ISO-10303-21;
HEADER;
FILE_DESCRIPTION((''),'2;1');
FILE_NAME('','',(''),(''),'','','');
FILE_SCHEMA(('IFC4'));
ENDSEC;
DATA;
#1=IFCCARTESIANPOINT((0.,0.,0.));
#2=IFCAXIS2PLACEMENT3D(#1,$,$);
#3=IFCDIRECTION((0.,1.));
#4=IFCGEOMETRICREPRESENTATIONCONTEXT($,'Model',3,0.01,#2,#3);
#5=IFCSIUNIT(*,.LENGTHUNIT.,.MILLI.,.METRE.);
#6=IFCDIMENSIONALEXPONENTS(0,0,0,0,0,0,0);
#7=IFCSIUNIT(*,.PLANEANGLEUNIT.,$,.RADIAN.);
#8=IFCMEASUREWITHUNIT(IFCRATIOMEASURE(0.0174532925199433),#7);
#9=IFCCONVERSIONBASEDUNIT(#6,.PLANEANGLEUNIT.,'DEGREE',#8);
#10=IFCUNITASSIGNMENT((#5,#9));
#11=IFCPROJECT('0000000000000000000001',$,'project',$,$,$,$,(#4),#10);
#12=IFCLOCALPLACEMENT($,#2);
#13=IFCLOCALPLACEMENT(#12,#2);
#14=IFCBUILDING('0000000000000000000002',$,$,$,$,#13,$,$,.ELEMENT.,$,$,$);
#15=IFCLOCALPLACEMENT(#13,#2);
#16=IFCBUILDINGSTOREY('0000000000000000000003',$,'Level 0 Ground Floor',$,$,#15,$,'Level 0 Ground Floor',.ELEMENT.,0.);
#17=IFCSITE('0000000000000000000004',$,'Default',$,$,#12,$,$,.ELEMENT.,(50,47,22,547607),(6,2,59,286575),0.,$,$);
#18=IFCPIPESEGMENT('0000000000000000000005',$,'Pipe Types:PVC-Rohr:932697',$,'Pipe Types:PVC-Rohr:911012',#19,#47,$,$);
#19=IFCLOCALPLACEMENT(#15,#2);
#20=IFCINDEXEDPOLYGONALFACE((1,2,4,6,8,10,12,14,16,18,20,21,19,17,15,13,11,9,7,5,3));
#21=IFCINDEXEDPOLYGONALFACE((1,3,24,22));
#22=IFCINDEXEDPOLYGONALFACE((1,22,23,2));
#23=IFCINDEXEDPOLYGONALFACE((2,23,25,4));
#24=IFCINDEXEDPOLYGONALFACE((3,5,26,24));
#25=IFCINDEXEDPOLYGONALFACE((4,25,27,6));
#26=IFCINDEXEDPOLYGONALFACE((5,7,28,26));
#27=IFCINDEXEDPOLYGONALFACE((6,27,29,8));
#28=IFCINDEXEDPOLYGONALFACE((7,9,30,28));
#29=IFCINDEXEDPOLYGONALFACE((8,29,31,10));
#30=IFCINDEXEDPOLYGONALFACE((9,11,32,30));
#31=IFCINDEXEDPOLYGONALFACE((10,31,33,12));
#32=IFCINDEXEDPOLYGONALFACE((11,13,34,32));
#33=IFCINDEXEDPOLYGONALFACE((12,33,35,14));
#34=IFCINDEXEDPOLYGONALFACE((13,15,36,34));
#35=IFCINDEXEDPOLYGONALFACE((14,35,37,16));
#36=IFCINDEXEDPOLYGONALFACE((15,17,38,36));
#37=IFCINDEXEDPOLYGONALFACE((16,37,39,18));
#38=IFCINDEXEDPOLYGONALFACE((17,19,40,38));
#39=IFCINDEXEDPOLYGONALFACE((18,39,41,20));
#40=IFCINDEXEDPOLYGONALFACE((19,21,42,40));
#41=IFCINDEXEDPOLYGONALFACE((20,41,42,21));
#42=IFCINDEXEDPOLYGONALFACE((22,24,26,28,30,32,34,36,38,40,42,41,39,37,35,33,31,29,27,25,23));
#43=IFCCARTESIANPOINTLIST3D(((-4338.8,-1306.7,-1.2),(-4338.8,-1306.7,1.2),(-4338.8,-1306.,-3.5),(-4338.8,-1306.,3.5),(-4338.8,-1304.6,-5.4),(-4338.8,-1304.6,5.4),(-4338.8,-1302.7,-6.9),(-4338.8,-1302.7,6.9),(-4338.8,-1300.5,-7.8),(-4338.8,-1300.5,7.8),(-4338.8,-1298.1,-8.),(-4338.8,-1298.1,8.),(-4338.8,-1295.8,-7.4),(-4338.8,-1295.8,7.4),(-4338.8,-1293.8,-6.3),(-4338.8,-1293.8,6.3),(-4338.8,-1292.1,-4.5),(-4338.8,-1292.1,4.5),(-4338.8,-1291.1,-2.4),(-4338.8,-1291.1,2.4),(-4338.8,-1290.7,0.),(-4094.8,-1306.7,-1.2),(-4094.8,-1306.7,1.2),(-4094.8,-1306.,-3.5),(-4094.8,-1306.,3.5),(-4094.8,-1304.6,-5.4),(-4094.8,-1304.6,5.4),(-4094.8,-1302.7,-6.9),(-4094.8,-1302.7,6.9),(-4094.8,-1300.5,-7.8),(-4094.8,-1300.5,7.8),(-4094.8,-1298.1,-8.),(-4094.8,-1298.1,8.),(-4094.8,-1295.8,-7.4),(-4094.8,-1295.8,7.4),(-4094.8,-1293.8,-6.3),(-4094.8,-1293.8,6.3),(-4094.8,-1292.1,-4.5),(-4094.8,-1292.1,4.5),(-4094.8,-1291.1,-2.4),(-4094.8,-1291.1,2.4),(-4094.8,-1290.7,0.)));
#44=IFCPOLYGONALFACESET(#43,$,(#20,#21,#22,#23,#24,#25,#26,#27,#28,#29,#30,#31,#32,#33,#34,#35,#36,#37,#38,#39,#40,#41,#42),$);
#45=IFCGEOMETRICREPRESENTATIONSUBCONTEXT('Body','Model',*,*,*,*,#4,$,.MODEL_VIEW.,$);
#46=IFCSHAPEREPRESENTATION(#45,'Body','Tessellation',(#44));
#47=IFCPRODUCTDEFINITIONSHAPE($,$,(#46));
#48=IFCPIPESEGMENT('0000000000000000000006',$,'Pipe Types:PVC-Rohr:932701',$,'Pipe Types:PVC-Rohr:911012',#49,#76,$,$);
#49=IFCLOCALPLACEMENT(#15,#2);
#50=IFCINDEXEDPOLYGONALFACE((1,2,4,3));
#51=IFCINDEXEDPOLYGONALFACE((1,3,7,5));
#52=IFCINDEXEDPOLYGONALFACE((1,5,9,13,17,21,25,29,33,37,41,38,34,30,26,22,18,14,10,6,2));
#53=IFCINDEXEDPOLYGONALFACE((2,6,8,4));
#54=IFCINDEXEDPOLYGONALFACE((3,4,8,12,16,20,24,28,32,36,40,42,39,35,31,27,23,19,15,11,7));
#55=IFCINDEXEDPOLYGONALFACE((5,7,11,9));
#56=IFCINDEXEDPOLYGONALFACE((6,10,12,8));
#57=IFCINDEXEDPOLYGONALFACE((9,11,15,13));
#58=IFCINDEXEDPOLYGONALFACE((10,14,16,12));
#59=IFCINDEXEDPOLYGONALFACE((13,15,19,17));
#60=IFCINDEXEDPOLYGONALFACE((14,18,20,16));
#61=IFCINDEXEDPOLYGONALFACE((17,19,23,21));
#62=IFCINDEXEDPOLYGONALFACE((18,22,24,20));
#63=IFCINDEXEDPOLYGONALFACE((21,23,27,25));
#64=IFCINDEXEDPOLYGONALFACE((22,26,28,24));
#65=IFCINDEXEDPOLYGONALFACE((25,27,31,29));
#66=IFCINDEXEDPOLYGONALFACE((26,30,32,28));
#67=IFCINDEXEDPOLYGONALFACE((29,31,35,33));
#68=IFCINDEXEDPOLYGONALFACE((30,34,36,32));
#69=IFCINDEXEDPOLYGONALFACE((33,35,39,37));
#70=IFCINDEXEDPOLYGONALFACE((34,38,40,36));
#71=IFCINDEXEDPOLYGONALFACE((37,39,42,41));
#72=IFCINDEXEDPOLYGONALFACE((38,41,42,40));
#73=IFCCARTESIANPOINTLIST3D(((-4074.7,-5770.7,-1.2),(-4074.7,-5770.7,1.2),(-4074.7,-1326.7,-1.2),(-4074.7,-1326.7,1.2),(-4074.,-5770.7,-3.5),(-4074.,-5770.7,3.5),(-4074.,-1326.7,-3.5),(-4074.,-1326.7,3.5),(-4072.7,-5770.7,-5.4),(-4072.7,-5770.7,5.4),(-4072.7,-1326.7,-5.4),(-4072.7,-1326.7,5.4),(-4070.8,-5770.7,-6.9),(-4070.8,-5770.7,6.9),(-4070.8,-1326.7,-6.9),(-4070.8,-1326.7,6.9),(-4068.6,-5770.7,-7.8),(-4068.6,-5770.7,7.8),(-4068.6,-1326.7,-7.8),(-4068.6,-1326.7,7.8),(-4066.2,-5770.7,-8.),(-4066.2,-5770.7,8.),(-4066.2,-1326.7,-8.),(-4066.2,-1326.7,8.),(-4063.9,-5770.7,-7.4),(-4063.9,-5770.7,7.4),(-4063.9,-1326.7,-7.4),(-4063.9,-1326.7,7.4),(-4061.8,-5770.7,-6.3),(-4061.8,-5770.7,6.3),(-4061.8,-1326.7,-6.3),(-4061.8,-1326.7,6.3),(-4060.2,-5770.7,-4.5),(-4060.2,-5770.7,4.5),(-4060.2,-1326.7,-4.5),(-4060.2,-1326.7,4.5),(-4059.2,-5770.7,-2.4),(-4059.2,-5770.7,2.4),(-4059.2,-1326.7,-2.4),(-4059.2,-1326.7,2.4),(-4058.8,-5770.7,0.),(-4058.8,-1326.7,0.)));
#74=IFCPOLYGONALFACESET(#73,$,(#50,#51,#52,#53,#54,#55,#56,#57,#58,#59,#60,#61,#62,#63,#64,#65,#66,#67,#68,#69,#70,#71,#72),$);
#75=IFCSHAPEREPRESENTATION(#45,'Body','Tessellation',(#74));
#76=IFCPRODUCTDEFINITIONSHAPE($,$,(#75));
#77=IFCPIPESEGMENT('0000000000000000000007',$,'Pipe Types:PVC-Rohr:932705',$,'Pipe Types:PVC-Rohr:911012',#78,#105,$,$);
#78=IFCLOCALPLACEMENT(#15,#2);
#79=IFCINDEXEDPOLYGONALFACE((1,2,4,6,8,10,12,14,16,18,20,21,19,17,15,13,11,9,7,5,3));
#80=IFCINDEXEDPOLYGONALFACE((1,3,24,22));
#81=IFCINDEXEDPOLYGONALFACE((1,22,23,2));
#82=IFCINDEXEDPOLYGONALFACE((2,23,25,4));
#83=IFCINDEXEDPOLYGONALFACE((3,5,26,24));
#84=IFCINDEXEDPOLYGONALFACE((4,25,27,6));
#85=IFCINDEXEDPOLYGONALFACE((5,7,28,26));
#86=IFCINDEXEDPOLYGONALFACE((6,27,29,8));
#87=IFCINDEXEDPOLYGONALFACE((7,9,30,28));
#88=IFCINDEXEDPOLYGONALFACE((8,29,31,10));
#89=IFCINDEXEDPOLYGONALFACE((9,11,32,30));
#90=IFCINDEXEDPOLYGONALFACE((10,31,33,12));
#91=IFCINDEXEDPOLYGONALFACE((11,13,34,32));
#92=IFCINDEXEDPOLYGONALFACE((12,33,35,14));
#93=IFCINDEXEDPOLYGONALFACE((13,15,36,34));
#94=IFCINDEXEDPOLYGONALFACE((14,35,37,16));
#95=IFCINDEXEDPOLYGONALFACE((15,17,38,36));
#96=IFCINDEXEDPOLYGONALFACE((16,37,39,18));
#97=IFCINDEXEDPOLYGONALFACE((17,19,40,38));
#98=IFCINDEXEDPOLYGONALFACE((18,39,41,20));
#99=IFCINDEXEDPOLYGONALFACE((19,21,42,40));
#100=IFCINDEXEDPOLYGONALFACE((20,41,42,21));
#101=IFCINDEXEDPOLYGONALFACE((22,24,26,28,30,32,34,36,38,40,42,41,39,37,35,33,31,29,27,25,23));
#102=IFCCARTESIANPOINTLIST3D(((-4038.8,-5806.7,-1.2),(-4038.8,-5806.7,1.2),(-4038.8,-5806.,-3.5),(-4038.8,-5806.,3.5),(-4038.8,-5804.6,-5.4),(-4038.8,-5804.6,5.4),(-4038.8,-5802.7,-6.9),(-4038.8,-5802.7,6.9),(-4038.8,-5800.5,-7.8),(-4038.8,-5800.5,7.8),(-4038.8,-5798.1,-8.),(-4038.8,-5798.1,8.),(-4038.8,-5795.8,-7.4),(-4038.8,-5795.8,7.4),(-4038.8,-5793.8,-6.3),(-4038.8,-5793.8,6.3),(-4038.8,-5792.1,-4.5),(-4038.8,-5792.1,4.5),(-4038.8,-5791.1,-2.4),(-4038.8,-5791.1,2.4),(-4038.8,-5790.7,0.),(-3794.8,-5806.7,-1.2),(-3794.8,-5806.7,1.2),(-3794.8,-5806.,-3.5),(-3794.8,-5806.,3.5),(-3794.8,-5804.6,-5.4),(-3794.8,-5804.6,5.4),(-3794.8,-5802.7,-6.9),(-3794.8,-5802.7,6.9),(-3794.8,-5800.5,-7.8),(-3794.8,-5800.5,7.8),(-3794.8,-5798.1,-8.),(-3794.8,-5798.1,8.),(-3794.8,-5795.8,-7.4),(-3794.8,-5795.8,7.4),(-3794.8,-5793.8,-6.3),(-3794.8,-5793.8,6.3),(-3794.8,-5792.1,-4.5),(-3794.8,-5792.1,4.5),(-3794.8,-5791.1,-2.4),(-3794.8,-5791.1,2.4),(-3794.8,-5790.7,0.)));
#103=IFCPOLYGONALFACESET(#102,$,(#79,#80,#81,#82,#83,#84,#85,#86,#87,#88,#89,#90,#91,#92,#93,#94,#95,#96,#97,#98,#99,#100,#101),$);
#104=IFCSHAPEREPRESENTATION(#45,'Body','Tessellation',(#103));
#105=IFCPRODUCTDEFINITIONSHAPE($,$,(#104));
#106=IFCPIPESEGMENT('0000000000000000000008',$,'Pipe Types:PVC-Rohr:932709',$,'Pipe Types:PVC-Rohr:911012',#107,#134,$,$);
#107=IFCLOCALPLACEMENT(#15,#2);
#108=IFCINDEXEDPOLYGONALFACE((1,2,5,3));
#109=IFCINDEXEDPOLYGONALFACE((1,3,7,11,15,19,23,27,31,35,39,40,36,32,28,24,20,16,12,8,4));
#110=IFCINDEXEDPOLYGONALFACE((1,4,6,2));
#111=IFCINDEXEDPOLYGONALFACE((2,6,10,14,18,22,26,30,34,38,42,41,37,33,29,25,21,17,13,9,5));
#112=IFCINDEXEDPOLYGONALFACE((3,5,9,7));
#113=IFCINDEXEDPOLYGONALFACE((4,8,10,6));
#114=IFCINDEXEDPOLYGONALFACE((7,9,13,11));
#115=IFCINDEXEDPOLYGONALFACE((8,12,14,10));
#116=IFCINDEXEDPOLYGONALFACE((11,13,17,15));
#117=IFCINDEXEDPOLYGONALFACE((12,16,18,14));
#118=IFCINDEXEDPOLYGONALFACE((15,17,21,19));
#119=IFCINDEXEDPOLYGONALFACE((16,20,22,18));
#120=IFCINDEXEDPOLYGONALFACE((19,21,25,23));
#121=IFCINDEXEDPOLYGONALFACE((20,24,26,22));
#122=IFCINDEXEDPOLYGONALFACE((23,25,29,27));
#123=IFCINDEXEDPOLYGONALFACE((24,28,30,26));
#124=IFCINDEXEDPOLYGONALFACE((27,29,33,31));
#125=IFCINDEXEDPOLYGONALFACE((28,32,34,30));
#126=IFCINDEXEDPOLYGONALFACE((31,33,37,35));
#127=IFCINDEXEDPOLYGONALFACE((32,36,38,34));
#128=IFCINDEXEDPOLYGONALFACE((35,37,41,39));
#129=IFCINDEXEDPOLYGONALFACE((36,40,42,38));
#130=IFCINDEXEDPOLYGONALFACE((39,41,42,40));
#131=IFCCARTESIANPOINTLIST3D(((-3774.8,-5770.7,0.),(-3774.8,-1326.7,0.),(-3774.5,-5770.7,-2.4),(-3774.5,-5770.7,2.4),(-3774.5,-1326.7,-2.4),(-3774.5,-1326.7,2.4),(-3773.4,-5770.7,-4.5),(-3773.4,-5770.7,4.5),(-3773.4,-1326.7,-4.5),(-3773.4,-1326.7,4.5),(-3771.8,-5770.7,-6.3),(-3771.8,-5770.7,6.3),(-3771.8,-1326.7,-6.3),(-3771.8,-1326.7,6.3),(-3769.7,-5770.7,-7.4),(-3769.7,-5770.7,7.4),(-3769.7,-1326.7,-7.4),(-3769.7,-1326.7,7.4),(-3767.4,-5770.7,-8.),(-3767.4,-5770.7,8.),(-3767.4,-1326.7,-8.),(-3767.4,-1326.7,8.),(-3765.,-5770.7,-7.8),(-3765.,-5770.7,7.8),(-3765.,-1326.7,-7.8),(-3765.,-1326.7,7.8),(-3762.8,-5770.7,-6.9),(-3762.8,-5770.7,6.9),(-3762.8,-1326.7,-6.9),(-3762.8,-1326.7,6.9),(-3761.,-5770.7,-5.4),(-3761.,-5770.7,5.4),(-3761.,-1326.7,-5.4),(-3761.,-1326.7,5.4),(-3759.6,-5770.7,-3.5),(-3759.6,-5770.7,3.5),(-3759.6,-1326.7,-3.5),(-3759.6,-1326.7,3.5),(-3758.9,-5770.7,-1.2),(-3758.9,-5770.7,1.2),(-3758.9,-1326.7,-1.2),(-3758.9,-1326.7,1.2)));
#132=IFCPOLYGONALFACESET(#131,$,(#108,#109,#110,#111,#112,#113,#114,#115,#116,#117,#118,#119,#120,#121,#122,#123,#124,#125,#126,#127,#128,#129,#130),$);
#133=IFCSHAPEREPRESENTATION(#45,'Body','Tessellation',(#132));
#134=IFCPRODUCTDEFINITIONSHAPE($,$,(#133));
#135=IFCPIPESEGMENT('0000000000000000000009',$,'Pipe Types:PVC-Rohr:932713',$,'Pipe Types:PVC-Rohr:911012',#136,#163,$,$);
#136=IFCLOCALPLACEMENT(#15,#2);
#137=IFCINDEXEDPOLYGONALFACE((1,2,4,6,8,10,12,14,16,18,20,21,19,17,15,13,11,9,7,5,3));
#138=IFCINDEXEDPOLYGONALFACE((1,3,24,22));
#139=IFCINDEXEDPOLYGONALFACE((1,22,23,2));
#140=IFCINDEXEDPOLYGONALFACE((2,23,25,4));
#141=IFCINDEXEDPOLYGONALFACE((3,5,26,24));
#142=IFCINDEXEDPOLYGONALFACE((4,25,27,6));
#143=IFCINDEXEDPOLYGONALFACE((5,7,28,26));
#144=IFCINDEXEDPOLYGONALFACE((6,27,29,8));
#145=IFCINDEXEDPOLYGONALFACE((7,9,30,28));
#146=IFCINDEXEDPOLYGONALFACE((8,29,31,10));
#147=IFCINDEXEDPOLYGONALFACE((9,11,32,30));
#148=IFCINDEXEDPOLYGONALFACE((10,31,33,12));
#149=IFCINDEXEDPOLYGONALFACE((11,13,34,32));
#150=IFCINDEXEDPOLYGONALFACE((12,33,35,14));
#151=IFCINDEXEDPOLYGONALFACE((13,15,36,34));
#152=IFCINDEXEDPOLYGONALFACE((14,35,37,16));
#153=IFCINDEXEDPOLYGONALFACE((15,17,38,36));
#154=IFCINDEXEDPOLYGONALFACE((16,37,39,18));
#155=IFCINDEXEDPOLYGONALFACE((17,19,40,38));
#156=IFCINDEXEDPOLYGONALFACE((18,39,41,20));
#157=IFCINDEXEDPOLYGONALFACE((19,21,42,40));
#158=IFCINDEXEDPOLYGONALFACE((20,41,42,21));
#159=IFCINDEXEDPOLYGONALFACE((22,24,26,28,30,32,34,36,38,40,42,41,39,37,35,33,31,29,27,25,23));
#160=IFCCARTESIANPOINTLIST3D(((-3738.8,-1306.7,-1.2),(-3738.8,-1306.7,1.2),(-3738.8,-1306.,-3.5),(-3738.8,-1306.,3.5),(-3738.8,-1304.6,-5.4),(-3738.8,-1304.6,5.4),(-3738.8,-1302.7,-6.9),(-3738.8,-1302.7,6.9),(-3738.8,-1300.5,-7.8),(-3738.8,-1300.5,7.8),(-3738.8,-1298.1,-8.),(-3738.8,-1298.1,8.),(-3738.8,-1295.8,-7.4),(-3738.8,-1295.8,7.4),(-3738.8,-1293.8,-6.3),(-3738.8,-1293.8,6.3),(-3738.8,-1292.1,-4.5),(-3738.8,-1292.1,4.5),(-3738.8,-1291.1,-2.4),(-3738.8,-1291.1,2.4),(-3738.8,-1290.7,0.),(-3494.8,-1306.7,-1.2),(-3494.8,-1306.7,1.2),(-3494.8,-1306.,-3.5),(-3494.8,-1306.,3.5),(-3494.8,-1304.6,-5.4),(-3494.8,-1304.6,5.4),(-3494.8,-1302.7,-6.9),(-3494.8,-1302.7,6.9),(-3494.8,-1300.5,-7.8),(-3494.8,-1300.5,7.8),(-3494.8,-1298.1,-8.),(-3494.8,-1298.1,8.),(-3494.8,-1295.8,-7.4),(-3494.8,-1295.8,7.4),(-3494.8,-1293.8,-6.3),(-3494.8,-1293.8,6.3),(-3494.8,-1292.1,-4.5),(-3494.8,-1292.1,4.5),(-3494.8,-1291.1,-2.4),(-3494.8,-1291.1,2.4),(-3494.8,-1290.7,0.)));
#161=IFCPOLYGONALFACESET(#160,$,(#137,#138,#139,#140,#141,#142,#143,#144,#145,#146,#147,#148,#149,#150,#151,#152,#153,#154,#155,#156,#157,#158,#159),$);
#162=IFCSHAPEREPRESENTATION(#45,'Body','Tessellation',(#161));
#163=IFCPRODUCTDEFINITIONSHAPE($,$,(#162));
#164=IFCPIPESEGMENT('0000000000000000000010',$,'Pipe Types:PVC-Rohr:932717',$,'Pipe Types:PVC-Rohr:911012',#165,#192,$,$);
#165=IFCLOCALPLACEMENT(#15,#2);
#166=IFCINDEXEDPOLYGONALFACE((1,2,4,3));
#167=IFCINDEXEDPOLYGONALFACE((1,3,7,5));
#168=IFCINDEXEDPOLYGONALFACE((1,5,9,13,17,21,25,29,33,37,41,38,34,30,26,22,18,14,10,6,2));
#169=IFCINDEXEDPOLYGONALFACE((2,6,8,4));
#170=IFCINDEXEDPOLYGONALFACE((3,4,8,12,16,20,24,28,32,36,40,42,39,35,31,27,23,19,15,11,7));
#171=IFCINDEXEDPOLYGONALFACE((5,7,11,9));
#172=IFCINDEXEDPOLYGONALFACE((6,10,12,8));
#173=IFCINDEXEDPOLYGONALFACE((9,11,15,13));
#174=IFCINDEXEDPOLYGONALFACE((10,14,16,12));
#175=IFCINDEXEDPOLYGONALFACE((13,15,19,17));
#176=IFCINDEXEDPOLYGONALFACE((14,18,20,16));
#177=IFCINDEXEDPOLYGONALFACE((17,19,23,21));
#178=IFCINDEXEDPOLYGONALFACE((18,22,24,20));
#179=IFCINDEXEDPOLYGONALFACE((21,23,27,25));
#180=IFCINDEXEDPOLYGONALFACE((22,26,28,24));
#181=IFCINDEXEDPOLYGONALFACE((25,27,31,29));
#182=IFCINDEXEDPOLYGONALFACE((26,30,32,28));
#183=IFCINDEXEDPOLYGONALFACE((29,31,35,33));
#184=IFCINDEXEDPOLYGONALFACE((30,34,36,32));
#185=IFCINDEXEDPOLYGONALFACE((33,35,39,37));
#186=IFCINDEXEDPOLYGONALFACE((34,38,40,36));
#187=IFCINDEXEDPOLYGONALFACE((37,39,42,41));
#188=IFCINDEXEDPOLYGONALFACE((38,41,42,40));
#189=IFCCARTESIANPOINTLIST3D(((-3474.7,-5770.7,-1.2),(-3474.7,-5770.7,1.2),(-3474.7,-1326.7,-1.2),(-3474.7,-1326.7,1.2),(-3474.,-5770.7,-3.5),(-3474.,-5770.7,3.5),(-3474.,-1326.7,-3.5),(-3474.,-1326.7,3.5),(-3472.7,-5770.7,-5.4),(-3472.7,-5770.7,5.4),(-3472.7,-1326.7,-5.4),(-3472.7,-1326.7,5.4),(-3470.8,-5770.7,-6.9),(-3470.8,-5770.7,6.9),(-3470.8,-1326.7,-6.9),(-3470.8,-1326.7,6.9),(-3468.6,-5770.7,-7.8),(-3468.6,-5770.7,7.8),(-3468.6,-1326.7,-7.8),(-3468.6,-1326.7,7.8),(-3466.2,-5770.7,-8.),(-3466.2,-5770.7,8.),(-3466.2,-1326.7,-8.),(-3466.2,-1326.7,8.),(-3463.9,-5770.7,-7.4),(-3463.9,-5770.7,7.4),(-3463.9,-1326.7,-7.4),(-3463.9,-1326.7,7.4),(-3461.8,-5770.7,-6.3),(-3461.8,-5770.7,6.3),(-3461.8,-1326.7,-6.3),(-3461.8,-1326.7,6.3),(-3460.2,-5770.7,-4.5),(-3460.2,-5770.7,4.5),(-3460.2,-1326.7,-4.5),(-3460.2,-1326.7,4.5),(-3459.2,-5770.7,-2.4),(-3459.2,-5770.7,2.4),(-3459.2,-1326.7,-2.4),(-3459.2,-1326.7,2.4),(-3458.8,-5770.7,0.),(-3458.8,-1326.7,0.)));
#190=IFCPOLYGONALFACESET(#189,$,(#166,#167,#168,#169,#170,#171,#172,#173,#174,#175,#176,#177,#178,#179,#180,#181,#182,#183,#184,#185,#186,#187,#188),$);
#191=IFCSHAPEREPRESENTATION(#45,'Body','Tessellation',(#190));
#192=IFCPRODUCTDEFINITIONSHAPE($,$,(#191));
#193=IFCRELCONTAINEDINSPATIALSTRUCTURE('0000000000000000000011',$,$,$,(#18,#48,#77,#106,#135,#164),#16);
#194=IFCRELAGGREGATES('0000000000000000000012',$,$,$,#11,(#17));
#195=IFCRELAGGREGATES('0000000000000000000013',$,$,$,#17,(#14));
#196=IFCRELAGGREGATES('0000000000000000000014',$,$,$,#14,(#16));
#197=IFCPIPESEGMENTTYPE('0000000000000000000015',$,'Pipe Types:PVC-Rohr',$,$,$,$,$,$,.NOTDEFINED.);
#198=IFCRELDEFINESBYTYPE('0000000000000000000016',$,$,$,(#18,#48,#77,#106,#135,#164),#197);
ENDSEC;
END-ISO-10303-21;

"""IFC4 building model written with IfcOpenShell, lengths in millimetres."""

from ifc_helpers import new_model, entity, si_unit, converted_unit, direction, frame, frame_2d, origin, place, context, subcontext, project, spatial, circle, extrude, type_object, element, save


model = new_model("IFC4")

# Units and contexts
model_context = context("Model", 3, precision=0.01, world=origin(), true_north=direction((0.0, 1.0)))
body_context = subcontext(model_context, "Body", "Model", "MODEL_VIEW")
ifc_project = project(units=[si_unit("LENGTHUNIT", "METRE", prefix="MILLI"), converted_unit("PLANEANGLEUNIT", "DEGREE", entity("IfcRatioMeasure", 0.0174532925199433), si_unit("PLANEANGLEUNIT", "RADIAN"), dimensions=[0, 0, 0, 0, 0, 0, 0])], contexts=[model_context])

# Site, building, storey
site_placement = place(None, origin())
site = spatial("IfcSite", under=ifc_project, at=site_placement, Name="Default", CompositionType="ELEMENT", RefLatitude=(50, 47, 22, 547607), RefLongitude=(6, 2, 59, 286575), RefElevation=0.0)
building_placement = place(site_placement, origin())
building = spatial("IfcBuilding", under=site, at=building_placement, CompositionType="ELEMENT")
storey_placement = place(building_placement, origin())
storey = spatial("IfcBuildingStorey", under=building, at=storey_placement, Name="Level 0 Ground Floor", LongName="Level 0 Ground Floor", CompositionType="ELEMENT", Elevation=0.0)

# Pipe segments
pipe_segment_type = type_object("IfcPipeSegmentType", Name="Pipe Types:PVC-Rohr", PredefinedType="NOTDEFINED")
pipe_segment_1_placement = place(storey_placement, frame((-4338.8, -1308.3, -9.6)))
element("IfcPipeSegment", 1, at=pipe_segment_1_placement, inside=storey, type_object=pipe_segment_type, Name="Pipe Types:PVC-Rohr:932697", ObjectType="Pipe Types:PVC-Rohr:911012", context=body_context, shape_type="SweptSolid", body=[
    extrude(circle(Radius=8.0, at=frame_2d((0.0, 0.0), x_axis=(1.0, 0.0))), frame((0.0, 9.6, 9.6), z_axis=(1.0, 0.0, 0.0), x_axis=(0.0, 1.0, 0.0)), (0.0, 0.0, 1.0), 244.0),
])
pipe_segment_2_placement = place(storey_placement, frame((-4076.4, -5770.7, -9.6)))
element("IfcPipeSegment", 2, at=pipe_segment_2_placement, inside=storey, type_object=pipe_segment_type, Name="Pipe Types:PVC-Rohr:932701", ObjectType="Pipe Types:PVC-Rohr:911012", context=body_context, shape_type="SweptSolid", body=[
    extrude(circle(Radius=8.0, at=frame_2d((0.0, 0.0), x_axis=(1.0, 0.0))), frame((9.6, 0.0, 9.6), z_axis=(0.0, 1.0, 0.0), x_axis=(1.0, 0.0, 0.0)), (0.0, 0.0, 1.0), 4444.0),
])
pipe_segment_3_placement = place(storey_placement, frame((-4038.8, -5808.3, -9.6)))
element("IfcPipeSegment", 3, at=pipe_segment_3_placement, inside=storey, type_object=pipe_segment_type, Name="Pipe Types:PVC-Rohr:932705", ObjectType="Pipe Types:PVC-Rohr:911012", context=body_context, shape_type="SweptSolid", body=[
    extrude(circle(Radius=8.0, at=frame_2d((0.0, 0.0), x_axis=(1.0, 0.0))), frame((0.0, 9.6, 9.6), z_axis=(1.0, 0.0, 0.0), x_axis=(0.0, 1.0, 0.0)), (0.0, 0.0, 1.0), 244.0),
])
pipe_segment_4_placement = place(storey_placement, frame((-3776.4, -5770.7, -9.6)))
element("IfcPipeSegment", 4, at=pipe_segment_4_placement, inside=storey, type_object=pipe_segment_type, Name="Pipe Types:PVC-Rohr:932709", ObjectType="Pipe Types:PVC-Rohr:911012", context=body_context, shape_type="SweptSolid", body=[
    extrude(circle(Radius=8.0, at=frame_2d((0.0, 0.0), x_axis=(1.0, 0.0))), frame((9.6, 0.0, 9.6), z_axis=(0.0, 1.0, 0.0), x_axis=(-1.0, 0.0, 0.0)), (0.0, 0.0, 1.0), 4444.0),
])
pipe_segment_5_placement = place(storey_placement, frame((-3738.8, -1308.3, -9.6)))
element("IfcPipeSegment", 5, at=pipe_segment_5_placement, inside=storey, type_object=pipe_segment_type, Name="Pipe Types:PVC-Rohr:932713", ObjectType="Pipe Types:PVC-Rohr:911012", context=body_context, shape_type="SweptSolid", body=[
    extrude(circle(Radius=8.0, at=frame_2d((0.0, 0.0), x_axis=(1.0, 0.0))), frame((0.0, 9.6, 9.6), z_axis=(1.0, 0.0, 0.0), x_axis=(0.0, 1.0, 0.0)), (0.0, 0.0, 1.0), 244.0),
])
pipe_segment_6_placement = place(storey_placement, frame((-3476.4, -5770.7, -9.6)))
element("IfcPipeSegment", 6, at=pipe_segment_6_placement, inside=storey, type_object=pipe_segment_type, Name="Pipe Types:PVC-Rohr:932717", ObjectType="Pipe Types:PVC-Rohr:911012", context=body_context, shape_type="SweptSolid", body=[
    extrude(circle(Radius=8.0, at=frame_2d((0.0, 0.0), x_axis=(1.0, 0.0))), frame((9.6, 0.0, 9.6), z_axis=(0.0, 1.0, 0.0), x_axis=(1.0, 0.0, 0.0)), (0.0, 0.0, 1.0), 4444.0),
])

save(model, "model.ifc")
